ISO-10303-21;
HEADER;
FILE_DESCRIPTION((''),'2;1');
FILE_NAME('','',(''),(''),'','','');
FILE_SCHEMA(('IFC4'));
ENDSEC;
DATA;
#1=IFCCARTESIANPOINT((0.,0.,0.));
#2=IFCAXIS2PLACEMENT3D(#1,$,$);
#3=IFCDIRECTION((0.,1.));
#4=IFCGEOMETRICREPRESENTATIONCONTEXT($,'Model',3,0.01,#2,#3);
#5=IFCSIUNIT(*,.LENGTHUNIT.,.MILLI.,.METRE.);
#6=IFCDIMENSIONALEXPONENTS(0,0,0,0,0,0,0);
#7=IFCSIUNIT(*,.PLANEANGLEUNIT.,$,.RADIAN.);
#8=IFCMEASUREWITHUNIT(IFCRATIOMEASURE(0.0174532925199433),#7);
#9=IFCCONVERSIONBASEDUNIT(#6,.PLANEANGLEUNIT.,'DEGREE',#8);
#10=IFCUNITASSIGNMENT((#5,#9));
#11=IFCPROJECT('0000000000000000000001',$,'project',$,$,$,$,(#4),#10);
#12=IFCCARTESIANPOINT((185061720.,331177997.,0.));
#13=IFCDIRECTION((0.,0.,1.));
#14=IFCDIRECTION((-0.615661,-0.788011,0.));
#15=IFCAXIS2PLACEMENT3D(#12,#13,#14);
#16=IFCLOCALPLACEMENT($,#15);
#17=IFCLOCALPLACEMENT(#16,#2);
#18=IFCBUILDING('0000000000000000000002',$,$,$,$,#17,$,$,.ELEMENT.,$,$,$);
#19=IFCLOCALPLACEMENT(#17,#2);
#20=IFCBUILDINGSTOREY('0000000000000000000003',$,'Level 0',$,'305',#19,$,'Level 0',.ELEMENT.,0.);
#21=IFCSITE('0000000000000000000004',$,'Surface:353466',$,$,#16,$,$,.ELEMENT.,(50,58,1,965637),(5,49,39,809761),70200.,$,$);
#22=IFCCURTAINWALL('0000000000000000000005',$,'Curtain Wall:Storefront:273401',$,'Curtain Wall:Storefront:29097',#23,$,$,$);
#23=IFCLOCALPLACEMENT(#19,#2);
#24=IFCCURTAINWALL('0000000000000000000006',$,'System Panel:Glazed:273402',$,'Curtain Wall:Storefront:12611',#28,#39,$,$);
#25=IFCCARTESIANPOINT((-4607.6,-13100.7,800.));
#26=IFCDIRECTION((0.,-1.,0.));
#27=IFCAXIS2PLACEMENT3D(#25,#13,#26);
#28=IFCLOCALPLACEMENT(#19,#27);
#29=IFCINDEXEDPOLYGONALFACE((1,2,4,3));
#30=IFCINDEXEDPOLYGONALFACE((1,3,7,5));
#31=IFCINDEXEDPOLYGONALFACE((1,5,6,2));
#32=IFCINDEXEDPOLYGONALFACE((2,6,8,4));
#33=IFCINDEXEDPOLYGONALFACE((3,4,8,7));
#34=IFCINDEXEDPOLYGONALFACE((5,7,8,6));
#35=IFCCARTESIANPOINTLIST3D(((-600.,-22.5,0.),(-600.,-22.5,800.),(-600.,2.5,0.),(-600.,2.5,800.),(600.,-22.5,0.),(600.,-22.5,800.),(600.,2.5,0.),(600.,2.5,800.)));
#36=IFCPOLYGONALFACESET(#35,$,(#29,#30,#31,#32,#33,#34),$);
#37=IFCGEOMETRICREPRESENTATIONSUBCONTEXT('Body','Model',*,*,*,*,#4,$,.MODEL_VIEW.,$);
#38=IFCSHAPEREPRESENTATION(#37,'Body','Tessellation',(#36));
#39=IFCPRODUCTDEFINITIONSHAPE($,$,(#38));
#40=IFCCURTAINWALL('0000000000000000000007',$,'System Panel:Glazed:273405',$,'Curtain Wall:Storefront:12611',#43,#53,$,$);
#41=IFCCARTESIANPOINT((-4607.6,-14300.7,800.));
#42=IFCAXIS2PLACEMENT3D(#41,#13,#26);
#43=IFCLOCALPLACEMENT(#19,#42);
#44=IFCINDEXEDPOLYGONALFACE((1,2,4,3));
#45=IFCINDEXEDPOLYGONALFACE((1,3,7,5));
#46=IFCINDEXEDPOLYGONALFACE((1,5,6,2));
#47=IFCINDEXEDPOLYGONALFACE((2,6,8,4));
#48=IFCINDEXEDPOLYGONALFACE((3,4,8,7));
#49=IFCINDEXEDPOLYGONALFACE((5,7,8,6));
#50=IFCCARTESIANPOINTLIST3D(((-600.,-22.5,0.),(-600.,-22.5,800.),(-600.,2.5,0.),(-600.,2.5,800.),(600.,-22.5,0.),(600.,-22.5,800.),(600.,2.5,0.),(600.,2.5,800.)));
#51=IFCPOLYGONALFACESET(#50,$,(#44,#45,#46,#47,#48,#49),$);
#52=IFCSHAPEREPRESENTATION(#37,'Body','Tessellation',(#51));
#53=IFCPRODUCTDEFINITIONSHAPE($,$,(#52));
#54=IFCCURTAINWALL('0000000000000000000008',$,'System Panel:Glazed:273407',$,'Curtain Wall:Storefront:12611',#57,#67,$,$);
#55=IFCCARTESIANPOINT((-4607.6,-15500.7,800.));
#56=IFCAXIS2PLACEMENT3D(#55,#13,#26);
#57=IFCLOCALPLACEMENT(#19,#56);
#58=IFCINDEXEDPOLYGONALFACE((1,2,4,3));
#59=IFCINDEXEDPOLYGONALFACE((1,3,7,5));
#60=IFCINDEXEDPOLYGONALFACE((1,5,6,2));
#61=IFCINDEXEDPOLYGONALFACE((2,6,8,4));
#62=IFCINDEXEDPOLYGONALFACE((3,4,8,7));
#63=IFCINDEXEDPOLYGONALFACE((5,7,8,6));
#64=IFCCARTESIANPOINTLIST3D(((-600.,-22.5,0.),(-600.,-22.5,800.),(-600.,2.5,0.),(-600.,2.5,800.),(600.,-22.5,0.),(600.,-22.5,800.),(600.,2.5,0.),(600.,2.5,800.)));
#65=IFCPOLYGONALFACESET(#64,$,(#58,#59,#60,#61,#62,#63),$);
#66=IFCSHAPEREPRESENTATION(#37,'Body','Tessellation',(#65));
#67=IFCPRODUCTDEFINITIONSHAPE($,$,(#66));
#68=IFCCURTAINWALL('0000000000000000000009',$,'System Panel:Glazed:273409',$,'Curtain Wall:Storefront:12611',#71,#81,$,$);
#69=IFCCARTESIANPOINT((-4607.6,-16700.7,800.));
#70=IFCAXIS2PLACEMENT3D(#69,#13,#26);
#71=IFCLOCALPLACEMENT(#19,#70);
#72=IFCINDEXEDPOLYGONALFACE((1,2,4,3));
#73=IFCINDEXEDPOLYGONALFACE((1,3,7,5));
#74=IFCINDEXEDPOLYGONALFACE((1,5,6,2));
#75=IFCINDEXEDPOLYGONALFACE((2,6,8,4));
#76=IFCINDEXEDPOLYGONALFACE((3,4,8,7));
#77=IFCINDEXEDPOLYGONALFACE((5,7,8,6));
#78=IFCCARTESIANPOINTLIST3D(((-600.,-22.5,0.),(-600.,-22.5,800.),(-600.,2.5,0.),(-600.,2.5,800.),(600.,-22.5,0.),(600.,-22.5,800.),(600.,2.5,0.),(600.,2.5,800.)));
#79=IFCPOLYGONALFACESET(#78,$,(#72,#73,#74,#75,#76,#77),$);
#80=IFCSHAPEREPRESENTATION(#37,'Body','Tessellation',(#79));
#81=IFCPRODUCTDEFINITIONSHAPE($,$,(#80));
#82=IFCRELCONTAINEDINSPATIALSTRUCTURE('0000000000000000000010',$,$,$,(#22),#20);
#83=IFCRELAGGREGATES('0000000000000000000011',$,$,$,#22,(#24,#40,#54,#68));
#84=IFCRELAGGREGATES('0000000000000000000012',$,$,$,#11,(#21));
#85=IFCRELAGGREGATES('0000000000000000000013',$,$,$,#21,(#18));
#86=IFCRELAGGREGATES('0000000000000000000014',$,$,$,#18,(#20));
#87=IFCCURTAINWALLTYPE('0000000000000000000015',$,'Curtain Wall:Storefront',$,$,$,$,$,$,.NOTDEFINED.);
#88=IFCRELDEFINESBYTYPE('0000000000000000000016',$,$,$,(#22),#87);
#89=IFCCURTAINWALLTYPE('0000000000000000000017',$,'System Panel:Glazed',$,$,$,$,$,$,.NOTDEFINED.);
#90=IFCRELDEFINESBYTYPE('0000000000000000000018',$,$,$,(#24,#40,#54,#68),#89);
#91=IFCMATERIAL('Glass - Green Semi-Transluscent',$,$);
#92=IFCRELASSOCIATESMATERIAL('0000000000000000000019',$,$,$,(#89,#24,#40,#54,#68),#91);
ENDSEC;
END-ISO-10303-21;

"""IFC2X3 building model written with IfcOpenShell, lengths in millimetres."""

from ifc_helpers import new_model, entity, si_unit, converted_unit, direction, frame, origin, origin_2d_with_axis, place, context, subcontext, project, spatial, rectangle, extrude, source, transform, mapped, material, type_object, type_shapes, element, aggregate, save


model = new_model("IFC2X3")

# Units and contexts
model_context = context("Model", 3, precision=0.01, world=origin(), true_north=direction((0.0, 1.0)))
body_context = subcontext(model_context, "Body", "Model", "MODEL_VIEW")
ifc_project = project(units=[si_unit("LENGTHUNIT", "METRE", prefix="MILLI"), converted_unit("PLANEANGLEUNIT", "DEGREE", entity("IfcRatioMeasure", 0.0174532925199433), si_unit("PLANEANGLEUNIT", "RADIAN"), dimensions=[0, 0, 0, 0, 0, 0, 0])], contexts=[model_context])

# Site, building, storey
site_placement = place(None, frame((185061720.0, 331177997.0, 0.0), z_axis=(0.0, 0.0, 1.0), x_axis=(-0.615661, -0.788011, 0.0)))
site = spatial("IfcSite", under=ifc_project, at=site_placement, Name="Surface:353466", CompositionType="ELEMENT", RefLatitude=(50, 58, 1, 965637), RefLongitude=(5, 49, 39, 809761), RefElevation=70200.0)
building_placement = place(site_placement, origin())
building = spatial("IfcBuilding", under=site, at=building_placement, CompositionType="ELEMENT")
storey_placement = place(building_placement, origin())
storey = spatial("IfcBuildingStorey", under=building, at=storey_placement, Name="Level 0", ObjectType="305", LongName="Level 0", CompositionType="ELEMENT", Elevation=0.0)

# Shared definitions
ifc_material_1 = material(Name="Glass - Green Semi-Transluscent")

# Curtain walls
curtain_wall_type_1 = type_object("IfcCurtainWallType", Name="Curtain Wall:Storefront", PredefinedType="NOTDEFINED")
curtain_wall_1_placement = place(storey_placement, origin())
curtain_wall_1 = element("IfcCurtainWall", 1, at=curtain_wall_1_placement, inside=storey, type_object=curtain_wall_type_1, Name="Curtain Wall:Storefront:273401", ObjectType="Curtain Wall:Storefront:29097")
curtain_wall_type_2 = type_object("IfcCurtainWallType", Name="System Panel:Glazed", PredefinedType="NOTDEFINED", material=ifc_material_1)
shared_shape_1 = source(origin(), body_context, "Body", "SweptSolid", [
    extrude(rectangle(XDim=25.0, YDim=1200.0, at=origin_2d_with_axis()), frame((0.0, -10.0, 0.0), z_axis=(0.0, 0.0, 1.0), x_axis=(0.0, 1.0, 0.0)), (0.0, 0.0, 1.0), 800.0),
])
type_shapes(curtain_wall_type_2, [shared_shape_1])
curtain_wall_2_placement = place(storey_placement, frame((-4607.6, -13100.7, 800.0), z_axis=(0.0, 0.0, 1.0), x_axis=(0.0, -1.0, 0.0)))
curtain_wall_2 = element("IfcCurtainWall", 2, at=curtain_wall_2_placement, type_object=curtain_wall_type_2, material=ifc_material_1, Name="System Panel:Glazed:273402", ObjectType="Curtain Wall:Storefront:12611", context=body_context, shape_type="MappedRepresentation", body=[
    mapped(shared_shape_1, transform((0.0, 0.0, 0.0), scale=1.0)),
])
curtain_wall_3_placement = place(storey_placement, frame((-4607.6, -14300.7, 800.0), z_axis=(0.0, 0.0, 1.0), x_axis=(0.0, -1.0, 0.0)))
curtain_wall_3 = element("IfcCurtainWall", 3, at=curtain_wall_3_placement, type_object=curtain_wall_type_2, material=ifc_material_1, Name="System Panel:Glazed:273405", ObjectType="Curtain Wall:Storefront:12611", context=body_context, shape_type="MappedRepresentation", body=[
    mapped(shared_shape_1, transform((0.0, 0.0, 0.0), scale=1.0)),
])
curtain_wall_4_placement = place(storey_placement, frame((-4607.6, -15500.7, 800.0), z_axis=(0.0, 0.0, 1.0), x_axis=(0.0, -1.0, 0.0)))
curtain_wall_4 = element("IfcCurtainWall", 4, at=curtain_wall_4_placement, type_object=curtain_wall_type_2, material=ifc_material_1, Name="System Panel:Glazed:273407", ObjectType="Curtain Wall:Storefront:12611", context=body_context, shape_type="MappedRepresentation", body=[
    mapped(shared_shape_1, transform((0.0, 0.0, 0.0), scale=1.0)),
])
curtain_wall_5_placement = place(storey_placement, frame((-4607.6, -16700.7, 800.0), z_axis=(0.0, 0.0, 1.0), x_axis=(0.0, -1.0, 0.0)))
curtain_wall_5 = element("IfcCurtainWall", 5, at=curtain_wall_5_placement, type_object=curtain_wall_type_2, material=ifc_material_1, Name="System Panel:Glazed:273409", ObjectType="Curtain Wall:Storefront:12611", context=body_context, shape_type="MappedRepresentation", body=[
    mapped(shared_shape_1, transform((0.0, 0.0, 0.0), scale=1.0)),
])
aggregate(curtain_wall_1, [curtain_wall_2, curtain_wall_3, curtain_wall_4, curtain_wall_5])

save(model, "model.ifc")
